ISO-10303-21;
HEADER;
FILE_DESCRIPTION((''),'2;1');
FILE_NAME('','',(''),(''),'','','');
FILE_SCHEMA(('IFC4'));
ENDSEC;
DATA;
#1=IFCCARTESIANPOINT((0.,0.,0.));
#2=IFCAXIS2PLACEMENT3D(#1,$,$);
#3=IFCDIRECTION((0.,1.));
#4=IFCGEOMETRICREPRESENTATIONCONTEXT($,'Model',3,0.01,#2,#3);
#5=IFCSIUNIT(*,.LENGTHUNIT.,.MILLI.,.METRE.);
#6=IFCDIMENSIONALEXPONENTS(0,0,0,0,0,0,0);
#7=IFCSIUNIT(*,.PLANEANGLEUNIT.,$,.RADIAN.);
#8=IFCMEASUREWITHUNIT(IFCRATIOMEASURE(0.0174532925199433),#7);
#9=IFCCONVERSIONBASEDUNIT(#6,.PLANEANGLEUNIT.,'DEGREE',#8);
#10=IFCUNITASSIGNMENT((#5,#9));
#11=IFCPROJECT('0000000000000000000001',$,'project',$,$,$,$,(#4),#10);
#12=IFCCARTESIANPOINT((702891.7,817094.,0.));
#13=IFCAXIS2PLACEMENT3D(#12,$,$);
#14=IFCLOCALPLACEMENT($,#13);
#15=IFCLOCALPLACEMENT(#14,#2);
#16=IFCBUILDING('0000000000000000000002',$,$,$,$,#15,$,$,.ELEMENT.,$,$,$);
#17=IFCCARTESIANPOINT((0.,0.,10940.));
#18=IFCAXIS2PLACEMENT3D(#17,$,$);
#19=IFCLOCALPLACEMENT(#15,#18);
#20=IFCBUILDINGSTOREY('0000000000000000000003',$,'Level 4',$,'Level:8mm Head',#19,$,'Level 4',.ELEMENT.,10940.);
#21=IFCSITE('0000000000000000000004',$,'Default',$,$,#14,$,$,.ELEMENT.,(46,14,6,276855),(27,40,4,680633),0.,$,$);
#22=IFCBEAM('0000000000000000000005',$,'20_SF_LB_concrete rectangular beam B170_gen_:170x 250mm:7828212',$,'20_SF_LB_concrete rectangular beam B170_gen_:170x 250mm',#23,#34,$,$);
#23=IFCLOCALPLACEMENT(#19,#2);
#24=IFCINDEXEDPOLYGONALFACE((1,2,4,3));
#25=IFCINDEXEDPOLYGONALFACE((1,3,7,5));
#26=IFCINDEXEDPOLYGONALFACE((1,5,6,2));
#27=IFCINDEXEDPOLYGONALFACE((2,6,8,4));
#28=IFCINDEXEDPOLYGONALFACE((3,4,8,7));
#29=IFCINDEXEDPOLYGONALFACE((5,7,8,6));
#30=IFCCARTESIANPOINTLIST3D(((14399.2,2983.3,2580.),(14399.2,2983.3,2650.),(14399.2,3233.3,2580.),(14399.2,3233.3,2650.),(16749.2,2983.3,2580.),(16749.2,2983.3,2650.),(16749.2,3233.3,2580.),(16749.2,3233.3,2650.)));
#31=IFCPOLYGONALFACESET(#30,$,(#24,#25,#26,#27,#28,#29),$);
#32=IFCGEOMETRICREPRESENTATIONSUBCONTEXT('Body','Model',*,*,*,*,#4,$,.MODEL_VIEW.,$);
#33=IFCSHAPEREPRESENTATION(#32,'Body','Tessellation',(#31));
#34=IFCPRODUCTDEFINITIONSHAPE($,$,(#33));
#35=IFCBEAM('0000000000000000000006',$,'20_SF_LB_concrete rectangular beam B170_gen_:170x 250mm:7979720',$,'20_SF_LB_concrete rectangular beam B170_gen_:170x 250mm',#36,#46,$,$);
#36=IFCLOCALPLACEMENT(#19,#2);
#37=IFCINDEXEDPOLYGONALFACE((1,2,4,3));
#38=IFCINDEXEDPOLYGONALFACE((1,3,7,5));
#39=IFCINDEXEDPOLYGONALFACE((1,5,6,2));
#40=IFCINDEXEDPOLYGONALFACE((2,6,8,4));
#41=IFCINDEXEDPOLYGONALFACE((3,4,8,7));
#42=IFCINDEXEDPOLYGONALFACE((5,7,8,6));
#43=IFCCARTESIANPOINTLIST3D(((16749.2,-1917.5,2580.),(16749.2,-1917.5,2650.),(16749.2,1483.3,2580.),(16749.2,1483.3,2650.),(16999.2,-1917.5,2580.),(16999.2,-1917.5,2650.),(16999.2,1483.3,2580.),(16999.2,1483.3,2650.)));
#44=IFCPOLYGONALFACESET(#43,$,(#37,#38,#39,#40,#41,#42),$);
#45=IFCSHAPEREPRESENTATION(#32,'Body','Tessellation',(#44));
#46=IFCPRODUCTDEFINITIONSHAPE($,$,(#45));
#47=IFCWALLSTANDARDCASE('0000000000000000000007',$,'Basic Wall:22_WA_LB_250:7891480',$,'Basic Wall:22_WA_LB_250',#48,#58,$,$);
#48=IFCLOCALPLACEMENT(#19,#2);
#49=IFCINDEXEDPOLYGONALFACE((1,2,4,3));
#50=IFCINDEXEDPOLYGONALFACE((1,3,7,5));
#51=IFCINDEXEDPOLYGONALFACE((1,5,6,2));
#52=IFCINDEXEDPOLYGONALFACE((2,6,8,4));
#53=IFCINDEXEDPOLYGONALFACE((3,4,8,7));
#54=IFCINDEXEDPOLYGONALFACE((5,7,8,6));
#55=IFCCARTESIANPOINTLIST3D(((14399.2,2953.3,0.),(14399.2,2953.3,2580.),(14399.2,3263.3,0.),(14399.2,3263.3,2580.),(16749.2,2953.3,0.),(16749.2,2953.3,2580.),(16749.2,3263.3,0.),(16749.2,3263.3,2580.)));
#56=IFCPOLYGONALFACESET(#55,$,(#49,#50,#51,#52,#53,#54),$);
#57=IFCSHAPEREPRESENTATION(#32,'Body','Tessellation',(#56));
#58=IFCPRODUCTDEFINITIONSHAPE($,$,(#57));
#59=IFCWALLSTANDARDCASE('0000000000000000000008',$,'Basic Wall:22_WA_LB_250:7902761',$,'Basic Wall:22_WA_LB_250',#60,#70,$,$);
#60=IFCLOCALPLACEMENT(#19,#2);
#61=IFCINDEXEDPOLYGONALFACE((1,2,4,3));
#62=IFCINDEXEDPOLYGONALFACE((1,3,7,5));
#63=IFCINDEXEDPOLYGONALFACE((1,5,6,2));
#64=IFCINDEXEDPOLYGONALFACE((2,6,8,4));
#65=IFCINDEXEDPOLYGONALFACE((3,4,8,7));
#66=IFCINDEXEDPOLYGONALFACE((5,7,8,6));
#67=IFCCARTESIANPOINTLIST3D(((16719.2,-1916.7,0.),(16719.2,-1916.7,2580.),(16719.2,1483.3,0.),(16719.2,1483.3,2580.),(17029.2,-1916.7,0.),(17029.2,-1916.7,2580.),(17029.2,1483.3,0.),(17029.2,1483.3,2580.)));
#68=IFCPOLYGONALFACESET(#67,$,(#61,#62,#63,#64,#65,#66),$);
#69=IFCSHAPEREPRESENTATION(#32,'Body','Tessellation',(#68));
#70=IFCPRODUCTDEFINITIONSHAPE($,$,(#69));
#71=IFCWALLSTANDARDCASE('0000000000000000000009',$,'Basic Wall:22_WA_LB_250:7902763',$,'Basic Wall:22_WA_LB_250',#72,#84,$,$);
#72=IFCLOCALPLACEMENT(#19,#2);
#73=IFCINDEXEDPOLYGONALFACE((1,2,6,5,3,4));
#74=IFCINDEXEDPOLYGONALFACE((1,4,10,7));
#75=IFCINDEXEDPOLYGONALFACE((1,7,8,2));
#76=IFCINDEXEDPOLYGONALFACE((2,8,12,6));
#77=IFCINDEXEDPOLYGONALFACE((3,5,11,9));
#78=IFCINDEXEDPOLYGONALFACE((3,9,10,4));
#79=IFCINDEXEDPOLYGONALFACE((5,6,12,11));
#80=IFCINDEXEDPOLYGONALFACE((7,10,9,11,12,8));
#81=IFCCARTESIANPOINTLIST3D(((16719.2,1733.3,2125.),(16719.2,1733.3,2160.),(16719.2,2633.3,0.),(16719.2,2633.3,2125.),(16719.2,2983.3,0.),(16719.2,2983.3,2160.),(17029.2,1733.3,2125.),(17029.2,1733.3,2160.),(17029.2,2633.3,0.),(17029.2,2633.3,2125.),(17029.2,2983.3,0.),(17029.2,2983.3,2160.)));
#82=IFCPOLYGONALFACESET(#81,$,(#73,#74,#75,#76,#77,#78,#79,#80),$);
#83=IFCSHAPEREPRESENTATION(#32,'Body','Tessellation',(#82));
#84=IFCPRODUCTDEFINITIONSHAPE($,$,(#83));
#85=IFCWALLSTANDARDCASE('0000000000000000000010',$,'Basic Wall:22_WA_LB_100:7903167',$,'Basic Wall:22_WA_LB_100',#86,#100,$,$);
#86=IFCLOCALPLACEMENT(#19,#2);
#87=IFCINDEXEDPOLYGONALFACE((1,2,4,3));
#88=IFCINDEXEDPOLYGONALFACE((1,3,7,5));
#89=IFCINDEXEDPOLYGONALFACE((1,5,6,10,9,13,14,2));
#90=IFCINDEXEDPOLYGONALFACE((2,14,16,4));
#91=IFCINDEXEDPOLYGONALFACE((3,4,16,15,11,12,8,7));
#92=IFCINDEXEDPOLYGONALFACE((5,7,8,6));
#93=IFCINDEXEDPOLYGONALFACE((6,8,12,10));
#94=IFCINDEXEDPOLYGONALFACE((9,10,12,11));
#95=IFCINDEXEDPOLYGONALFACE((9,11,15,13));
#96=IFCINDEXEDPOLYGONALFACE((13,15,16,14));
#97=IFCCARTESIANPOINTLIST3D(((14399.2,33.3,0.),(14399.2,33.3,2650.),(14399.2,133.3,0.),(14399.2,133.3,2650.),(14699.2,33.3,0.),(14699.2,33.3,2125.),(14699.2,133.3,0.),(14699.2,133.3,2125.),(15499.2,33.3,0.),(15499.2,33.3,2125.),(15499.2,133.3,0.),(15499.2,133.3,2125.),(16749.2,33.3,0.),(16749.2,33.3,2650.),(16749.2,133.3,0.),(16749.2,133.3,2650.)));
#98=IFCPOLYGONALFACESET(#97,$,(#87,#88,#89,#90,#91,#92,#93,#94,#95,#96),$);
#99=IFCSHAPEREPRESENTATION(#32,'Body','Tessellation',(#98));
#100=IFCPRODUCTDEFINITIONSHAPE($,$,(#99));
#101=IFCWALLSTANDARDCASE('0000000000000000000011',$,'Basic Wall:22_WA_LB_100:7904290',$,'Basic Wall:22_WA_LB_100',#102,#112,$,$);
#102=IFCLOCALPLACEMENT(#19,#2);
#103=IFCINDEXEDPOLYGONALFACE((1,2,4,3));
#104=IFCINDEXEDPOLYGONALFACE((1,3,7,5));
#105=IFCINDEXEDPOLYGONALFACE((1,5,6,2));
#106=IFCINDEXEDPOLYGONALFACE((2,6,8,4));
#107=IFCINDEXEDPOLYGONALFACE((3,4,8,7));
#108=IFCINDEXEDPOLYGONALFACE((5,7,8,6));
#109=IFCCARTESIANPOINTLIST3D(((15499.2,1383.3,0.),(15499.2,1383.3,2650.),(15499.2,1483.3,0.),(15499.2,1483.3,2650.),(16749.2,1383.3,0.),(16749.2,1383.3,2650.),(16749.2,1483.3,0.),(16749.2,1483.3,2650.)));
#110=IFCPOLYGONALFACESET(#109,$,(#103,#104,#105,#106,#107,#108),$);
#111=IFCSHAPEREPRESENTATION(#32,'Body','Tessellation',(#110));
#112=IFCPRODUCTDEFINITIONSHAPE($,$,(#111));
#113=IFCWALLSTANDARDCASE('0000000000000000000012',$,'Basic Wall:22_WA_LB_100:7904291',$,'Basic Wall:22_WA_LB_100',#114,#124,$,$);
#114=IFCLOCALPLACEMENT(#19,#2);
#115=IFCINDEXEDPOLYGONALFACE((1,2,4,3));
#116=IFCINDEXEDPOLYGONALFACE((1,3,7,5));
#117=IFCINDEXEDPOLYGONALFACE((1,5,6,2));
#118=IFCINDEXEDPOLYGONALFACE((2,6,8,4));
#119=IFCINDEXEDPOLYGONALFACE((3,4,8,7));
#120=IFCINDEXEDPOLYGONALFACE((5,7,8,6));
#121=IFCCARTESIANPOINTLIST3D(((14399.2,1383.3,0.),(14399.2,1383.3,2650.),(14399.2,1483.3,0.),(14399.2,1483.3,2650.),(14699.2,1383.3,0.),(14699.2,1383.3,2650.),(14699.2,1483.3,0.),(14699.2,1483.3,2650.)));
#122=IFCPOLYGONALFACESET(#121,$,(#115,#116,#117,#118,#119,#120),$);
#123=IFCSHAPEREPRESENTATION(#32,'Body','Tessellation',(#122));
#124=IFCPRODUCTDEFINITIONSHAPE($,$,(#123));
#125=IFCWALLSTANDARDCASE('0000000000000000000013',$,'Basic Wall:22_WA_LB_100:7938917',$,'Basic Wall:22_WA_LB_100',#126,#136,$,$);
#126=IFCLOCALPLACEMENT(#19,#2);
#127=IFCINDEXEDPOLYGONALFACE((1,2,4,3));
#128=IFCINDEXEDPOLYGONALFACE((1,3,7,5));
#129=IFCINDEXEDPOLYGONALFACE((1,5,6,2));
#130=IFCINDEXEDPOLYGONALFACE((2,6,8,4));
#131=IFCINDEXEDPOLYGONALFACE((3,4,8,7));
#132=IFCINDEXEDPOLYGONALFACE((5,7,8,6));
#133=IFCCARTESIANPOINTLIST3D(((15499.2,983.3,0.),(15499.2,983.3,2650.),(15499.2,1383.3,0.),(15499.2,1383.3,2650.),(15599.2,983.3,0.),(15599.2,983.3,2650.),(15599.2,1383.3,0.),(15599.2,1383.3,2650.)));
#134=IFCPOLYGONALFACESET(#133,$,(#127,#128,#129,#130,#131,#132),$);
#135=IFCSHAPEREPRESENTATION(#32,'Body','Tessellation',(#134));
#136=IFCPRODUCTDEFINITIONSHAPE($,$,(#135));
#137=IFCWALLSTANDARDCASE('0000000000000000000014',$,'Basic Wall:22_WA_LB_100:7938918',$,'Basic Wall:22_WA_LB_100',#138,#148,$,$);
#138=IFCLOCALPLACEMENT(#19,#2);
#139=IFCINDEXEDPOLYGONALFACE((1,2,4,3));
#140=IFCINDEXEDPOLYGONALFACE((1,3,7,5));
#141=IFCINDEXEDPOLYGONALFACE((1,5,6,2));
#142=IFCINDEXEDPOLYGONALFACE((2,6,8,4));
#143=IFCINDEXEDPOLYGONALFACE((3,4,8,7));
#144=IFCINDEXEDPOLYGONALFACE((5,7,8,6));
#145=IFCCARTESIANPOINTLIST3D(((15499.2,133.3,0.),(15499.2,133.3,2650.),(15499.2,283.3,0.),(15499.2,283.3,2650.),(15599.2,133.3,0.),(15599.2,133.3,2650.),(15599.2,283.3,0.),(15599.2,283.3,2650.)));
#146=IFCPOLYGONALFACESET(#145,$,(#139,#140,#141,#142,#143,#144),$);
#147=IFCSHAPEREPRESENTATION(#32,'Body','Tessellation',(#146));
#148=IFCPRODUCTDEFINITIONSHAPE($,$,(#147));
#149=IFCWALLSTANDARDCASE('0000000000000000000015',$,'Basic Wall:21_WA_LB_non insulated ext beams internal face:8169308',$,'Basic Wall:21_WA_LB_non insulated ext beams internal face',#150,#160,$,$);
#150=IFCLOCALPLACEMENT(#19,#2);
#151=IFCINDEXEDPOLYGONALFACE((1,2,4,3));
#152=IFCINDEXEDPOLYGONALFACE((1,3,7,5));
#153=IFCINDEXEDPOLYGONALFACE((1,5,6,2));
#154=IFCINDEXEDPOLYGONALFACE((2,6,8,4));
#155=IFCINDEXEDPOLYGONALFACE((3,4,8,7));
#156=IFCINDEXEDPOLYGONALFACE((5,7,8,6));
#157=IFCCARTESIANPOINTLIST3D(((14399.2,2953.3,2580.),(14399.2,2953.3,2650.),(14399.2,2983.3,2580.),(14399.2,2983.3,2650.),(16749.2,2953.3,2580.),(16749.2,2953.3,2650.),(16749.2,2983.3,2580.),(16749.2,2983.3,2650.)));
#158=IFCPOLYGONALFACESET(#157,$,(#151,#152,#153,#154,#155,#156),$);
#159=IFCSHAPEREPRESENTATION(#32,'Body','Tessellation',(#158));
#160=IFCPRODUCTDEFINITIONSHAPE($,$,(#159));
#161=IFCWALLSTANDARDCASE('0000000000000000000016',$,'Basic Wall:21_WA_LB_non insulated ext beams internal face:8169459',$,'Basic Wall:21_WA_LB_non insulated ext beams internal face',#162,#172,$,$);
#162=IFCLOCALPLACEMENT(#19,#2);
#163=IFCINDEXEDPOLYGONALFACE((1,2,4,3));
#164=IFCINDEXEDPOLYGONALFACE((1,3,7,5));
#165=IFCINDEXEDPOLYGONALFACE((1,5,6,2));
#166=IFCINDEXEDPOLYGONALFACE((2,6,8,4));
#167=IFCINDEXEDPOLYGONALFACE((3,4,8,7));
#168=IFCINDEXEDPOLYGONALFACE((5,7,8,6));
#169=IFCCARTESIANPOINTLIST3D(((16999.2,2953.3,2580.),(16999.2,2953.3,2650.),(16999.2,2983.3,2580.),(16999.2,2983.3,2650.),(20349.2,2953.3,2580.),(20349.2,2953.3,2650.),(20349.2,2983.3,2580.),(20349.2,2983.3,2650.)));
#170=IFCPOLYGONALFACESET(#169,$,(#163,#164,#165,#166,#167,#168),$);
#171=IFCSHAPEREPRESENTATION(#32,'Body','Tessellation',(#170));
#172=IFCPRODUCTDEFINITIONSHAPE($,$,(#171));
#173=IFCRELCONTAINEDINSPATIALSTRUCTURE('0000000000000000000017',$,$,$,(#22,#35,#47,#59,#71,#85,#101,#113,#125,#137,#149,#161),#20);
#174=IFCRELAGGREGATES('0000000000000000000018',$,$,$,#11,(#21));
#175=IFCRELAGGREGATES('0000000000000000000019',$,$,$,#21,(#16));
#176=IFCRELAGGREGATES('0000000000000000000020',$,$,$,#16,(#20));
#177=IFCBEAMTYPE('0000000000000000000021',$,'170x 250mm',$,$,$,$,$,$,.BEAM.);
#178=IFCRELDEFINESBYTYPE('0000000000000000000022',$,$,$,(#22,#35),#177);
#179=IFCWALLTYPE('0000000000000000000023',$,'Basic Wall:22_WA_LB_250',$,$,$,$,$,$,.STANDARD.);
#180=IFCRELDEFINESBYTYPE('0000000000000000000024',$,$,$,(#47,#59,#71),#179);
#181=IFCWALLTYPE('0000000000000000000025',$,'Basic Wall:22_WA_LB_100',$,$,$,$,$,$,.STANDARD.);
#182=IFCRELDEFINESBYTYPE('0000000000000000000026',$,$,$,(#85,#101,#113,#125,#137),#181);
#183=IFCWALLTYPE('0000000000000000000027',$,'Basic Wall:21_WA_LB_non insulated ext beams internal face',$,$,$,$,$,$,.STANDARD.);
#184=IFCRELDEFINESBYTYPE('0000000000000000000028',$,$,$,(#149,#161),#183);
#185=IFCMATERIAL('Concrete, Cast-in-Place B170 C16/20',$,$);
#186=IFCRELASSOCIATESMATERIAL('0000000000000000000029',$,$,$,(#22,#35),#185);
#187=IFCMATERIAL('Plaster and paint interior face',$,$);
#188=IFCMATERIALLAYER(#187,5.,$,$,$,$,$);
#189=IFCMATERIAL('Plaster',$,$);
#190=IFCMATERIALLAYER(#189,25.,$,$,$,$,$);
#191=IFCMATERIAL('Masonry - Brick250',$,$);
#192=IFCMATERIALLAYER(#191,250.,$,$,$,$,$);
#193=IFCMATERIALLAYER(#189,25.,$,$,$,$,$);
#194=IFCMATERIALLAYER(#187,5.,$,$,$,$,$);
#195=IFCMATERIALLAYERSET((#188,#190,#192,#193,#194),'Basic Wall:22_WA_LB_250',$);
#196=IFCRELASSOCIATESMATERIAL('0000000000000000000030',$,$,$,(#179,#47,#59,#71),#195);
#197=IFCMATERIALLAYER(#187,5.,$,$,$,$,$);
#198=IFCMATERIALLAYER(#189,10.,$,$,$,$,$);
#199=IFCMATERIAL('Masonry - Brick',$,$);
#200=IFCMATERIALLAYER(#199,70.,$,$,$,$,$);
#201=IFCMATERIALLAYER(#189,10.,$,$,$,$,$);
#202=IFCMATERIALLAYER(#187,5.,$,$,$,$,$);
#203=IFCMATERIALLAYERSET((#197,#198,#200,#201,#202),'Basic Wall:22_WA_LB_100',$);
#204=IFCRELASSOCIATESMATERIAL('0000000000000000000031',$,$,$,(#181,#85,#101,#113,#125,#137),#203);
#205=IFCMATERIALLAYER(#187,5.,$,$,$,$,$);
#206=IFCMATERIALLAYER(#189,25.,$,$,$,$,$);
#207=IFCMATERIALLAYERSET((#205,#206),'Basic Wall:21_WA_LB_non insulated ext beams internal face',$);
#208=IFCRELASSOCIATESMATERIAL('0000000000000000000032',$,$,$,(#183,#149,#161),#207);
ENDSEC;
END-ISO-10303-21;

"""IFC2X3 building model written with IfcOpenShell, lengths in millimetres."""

from ifc_helpers import new_model, entity, si_unit, converted_unit, direction, frame, frame_2d, origin, place, context, subcontext, project, spatial, rectangle, extrude, material, layer, layer_set, layer_usage, type_object, element, save


model = new_model("IFC2X3")

# Units and contexts
model_context = context("Model", 3, precision=0.01, world=origin(), true_north=direction((0.0, 1.0)))
body_context = subcontext(model_context, "Body", "Model", "MODEL_VIEW")
ifc_project = project(units=[si_unit("LENGTHUNIT", "METRE", prefix="MILLI"), converted_unit("PLANEANGLEUNIT", "DEGREE", entity("IfcRatioMeasure", 0.0174532925199433), si_unit("PLANEANGLEUNIT", "RADIAN"), dimensions=[0, 0, 0, 0, 0, 0, 0])], contexts=[model_context])

# Site, building, storey
site_placement = place(None, frame((702891.7, 817094.0, 0.0)))
site = spatial("IfcSite", under=ifc_project, at=site_placement, Name="Default", CompositionType="ELEMENT", RefLatitude=(46, 14, 6, 276855), RefLongitude=(27, 40, 4, 680633), RefElevation=0.0)
building_placement = place(site_placement, origin())
building = spatial("IfcBuilding", under=site, at=building_placement, CompositionType="ELEMENT")
storey_placement = place(building_placement, frame((0.0, 0.0, 10940.0)))
storey = spatial("IfcBuildingStorey", under=building, at=storey_placement, Name="Level 4", ObjectType="Level:8mm Head", LongName="Level 4", CompositionType="ELEMENT", Elevation=10940.0)

# Beams
ifc_material_1 = material(Name="Concrete, Cast-in-Place B170 C16/20")
beam_type = type_object("IfcBeamType", Name="170x 250mm", PredefinedType="BEAM")
beam_1_placement = place(storey_placement, frame((14399.2, 3108.3, 0.0)))
element("IfcBeam", 1, at=beam_1_placement, inside=storey, type_object=beam_type, material=ifc_material_1, Name="20_SF_LB_concrete rectangular beam B170_gen_:170x 250mm:7828212", ObjectType="20_SF_LB_concrete rectangular beam B170_gen_:170x 250mm", context=body_context, shape_type="SweptSolid", body=[
    extrude(rectangle(XDim=70.0, YDim=250.0, at=frame_2d((0.0, 0.0), x_axis=(1.0, 0.0))), frame((0.0, 0.0, 2615.0), z_axis=(1.0, 0.0, 0.0), x_axis=(0.0, 0.0, -1.0)), (0.0, 0.0, 1.0), 2350.0),
])
beam_2_placement = place(storey_placement, frame((16874.2, 1483.3, 0.0), z_axis=(0.0, 0.0, 1.0), x_axis=(0.0, -1.0, 0.0)))
element("IfcBeam", 2, at=beam_2_placement, inside=storey, type_object=beam_type, material=ifc_material_1, Name="20_SF_LB_concrete rectangular beam B170_gen_:170x 250mm:7979720", ObjectType="20_SF_LB_concrete rectangular beam B170_gen_:170x 250mm", context=body_context, shape_type="SweptSolid", body=[
    extrude(rectangle(XDim=70.0, YDim=250.0, at=frame_2d((0.0, 0.0), x_axis=(1.0, 0.0))), frame((0.0, 0.0, 2615.0), z_axis=(1.0, 0.0, 0.0), x_axis=(0.0, 0.0, -1.0)), (0.0, 0.0, 1.0), 3400.8),
])

# Walls
ifc_material_2 = material(Name="Plaster and paint interior face")
ifc_layer_1 = layer(ifc_material_2, 5.0)
ifc_material_3 = material(Name="Plaster")
ifc_layer_2 = layer(ifc_material_3, 25.0)
ifc_material_4 = material(Name="Masonry - Brick250")
ifc_layer_3 = layer(ifc_material_4, 250.0)
ifc_layer_4 = layer(ifc_material_3, 25.0)
ifc_layer_5 = layer(ifc_material_2, 5.0)
ifc_layer_set_1 = layer_set([ifc_layer_1, ifc_layer_2, ifc_layer_3, ifc_layer_4, ifc_layer_5], Name="Basic Wall:22_WA_LB_250")
ifc_layer_usage_1 = layer_usage(ifc_layer_set_1, "AXIS2", "NEGATIVE", 155.0)
wall_type_1 = type_object("IfcWallType", Name="Basic Wall:22_WA_LB_250", PredefinedType="STANDARD", material=ifc_layer_set_1)
wall_1_placement = place(storey_placement, frame((14399.2, 3108.3, 0.0)))
element("IfcWallStandardCase", 3, at=wall_1_placement, inside=storey, type_object=wall_type_1, material=ifc_layer_usage_1, Name="Basic Wall:22_WA_LB_250:7891480", ObjectType="Basic Wall:22_WA_LB_250", context=body_context, shape_type="SweptSolid", body=[
    extrude(rectangle(XDim=2350.0, YDim=310.0, at=frame_2d((1175.0, 0.0), x_axis=(-1.0, 0.0))), origin(), (0.0, 0.0, 1.0), 2580.0),
])
ifc_layer_usage_2 = layer_usage(ifc_layer_set_1, "AXIS2", "NEGATIVE", 155.0)
wall_2_placement = place(storey_placement, frame((16874.2, 1483.3, 0.0), z_axis=(0.0, 0.0, 1.0), x_axis=(0.0, -1.0, 0.0)))
element("IfcWallStandardCase", 4, at=wall_2_placement, inside=storey, type_object=wall_type_1, material=ifc_layer_usage_2, Name="Basic Wall:22_WA_LB_250:7902761", ObjectType="Basic Wall:22_WA_LB_250", context=body_context, shape_type="SweptSolid", body=[
    extrude(rectangle(XDim=3400.0, YDim=310.0, at=frame_2d((1700.0, 0.0), x_axis=(-1.0, 0.0))), origin(), (0.0, 0.0, 1.0), 2580.0),
])

# Walls, openings
ifc_layer_usage_3 = layer_usage(ifc_layer_set_1, "AXIS2", "NEGATIVE", 155.0)
wall_3_placement = place(storey_placement, frame((16874.2, 2983.3, 0.0), z_axis=(0.0, 0.0, 1.0), x_axis=(0.0, -1.0, 0.0)))
wall_3 = element("IfcWallStandardCase", 5, at=wall_3_placement, inside=storey, type_object=wall_type_1, material=ifc_layer_usage_3, Name="Basic Wall:22_WA_LB_250:7902763", ObjectType="Basic Wall:22_WA_LB_250", context=body_context, shape_type="SweptSolid", body=[
    extrude(rectangle(XDim=1250.0, YDim=310.0, at=frame_2d((625.0, 0.0), x_axis=(-1.0, 0.0))), origin(), (0.0, 0.0, 1.0), 2160.0),
])
opening_1_placement = place(wall_3_placement, frame((2983.3, -16874.2, 0.0), z_axis=(0.0, 0.0, 1.0), x_axis=(0.0, 1.0, 0.0)))
element("IfcOpeningElement", 6, at=opening_1_placement, cuts=wall_3, ObjectType="Opening", context=body_context, shape_type="SweptSolid", body=[
    extrude(rectangle(XDim=2125.0, YDim=900.0, at=frame_2d((0.0, 0.0), x_axis=(0.0, 1.0))), frame((15195.2, 2183.3, 1062.5), z_axis=(1.0, 0.0, 0.0), x_axis=(0.0, 1.0, 0.0)), (0.0, 0.0, 1.0), 3048.0),
])
ifc_layer_6 = layer(ifc_material_2, 5.0)
ifc_layer_7 = layer(ifc_material_3, 10.0)
ifc_material_5 = material(Name="Masonry - Brick")
ifc_layer_8 = layer(ifc_material_5, 70.0)
ifc_layer_9 = layer(ifc_material_3, 10.0)
ifc_layer_10 = layer(ifc_material_2, 5.0)
ifc_layer_set_2 = layer_set([ifc_layer_6, ifc_layer_7, ifc_layer_8, ifc_layer_9, ifc_layer_10], Name="Basic Wall:22_WA_LB_100")
ifc_layer_usage_4 = layer_usage(ifc_layer_set_2, "AXIS2", "NEGATIVE", 50.0)
wall_type_2 = type_object("IfcWallType", Name="Basic Wall:22_WA_LB_100", PredefinedType="STANDARD", material=ifc_layer_set_2)
wall_4_placement = place(storey_placement, frame((16749.2, 83.3, 0.0), z_axis=(0.0, 0.0, 1.0), x_axis=(-1.0, 0.0, 0.0)))
wall_4 = element("IfcWallStandardCase", 7, at=wall_4_placement, inside=storey, type_object=wall_type_2, material=ifc_layer_usage_4, Name="Basic Wall:22_WA_LB_100:7903167", ObjectType="Basic Wall:22_WA_LB_100", context=body_context, shape_type="SweptSolid", body=[
    extrude(rectangle(XDim=2350.0, YDim=100.0, at=frame_2d((1175.0, 0.0), x_axis=(-1.0, 0.0))), origin(), (0.0, 0.0, 1.0), 2650.0),
])
opening_2_placement = place(wall_4_placement, frame((16749.2, 83.3, 0.0), z_axis=(0.0, 0.0, 1.0), x_axis=(-1.0, 0.0, 0.0)))
element("IfcOpeningElement", 8, at=opening_2_placement, cuts=wall_4, ObjectType="Opening", context=body_context, shape_type="SweptSolid", body=[
    extrude(rectangle(XDim=2125.0, YDim=800.0, at=frame_2d((0.0, 0.0), x_axis=(1.0, 0.0))), frame((15099.2, 1657.3, 1062.5), z_axis=(0.0, -1.0, 0.0), x_axis=(0.0, 0.0, 1.0)), (0.0, 0.0, 1.0), 3048.0),
])

# Walls
ifc_layer_usage_5 = layer_usage(ifc_layer_set_2, "AXIS2", "NEGATIVE", 50.0)
wall_5_placement = place(storey_placement, frame((15499.2, 1433.3, 0.0)))
element("IfcWallStandardCase", 9, at=wall_5_placement, inside=storey, type_object=wall_type_2, material=ifc_layer_usage_5, Name="Basic Wall:22_WA_LB_100:7904290", ObjectType="Basic Wall:22_WA_LB_100", context=body_context, shape_type="SweptSolid", body=[
    extrude(rectangle(XDim=1250.0, YDim=100.0, at=frame_2d((625.0, 0.0), x_axis=(-1.0, 0.0))), origin(), (0.0, 0.0, 1.0), 2650.0),
])
ifc_layer_usage_6 = layer_usage(ifc_layer_set_2, "AXIS2", "NEGATIVE", 50.0)
wall_6_placement = place(storey_placement, frame((14399.2, 1433.3, 0.0)))
element("IfcWallStandardCase", 10, at=wall_6_placement, inside=storey, type_object=wall_type_2, material=ifc_layer_usage_6, Name="Basic Wall:22_WA_LB_100:7904291", ObjectType="Basic Wall:22_WA_LB_100", context=body_context, shape_type="SweptSolid", body=[
    extrude(rectangle(XDim=300.0, YDim=100.0, at=frame_2d((150.0, 0.0), x_axis=(-1.0, 0.0))), origin(), (0.0, 0.0, 1.0), 2650.0),
])
ifc_layer_usage_7 = layer_usage(ifc_layer_set_2, "AXIS2", "NEGATIVE", 50.0)
wall_7_placement = place(storey_placement, frame((15549.2, 1383.3, 0.0), z_axis=(0.0, 0.0, 1.0), x_axis=(0.0, -1.0, 0.0)))
element("IfcWallStandardCase", 11, at=wall_7_placement, inside=storey, type_object=wall_type_2, material=ifc_layer_usage_7, Name="Basic Wall:22_WA_LB_100:7938917", ObjectType="Basic Wall:22_WA_LB_100", context=body_context, shape_type="SweptSolid", body=[
    extrude(rectangle(XDim=400.0, YDim=100.0, at=frame_2d((200.0, 0.0), x_axis=(-1.0, 0.0))), origin(), (0.0, 0.0, 1.0), 2650.0),
])
ifc_layer_usage_8 = layer_usage(ifc_layer_set_2, "AXIS2", "NEGATIVE", 50.0)
wall_8_placement = place(storey_placement, frame((15549.2, 283.3, 0.0), z_axis=(0.0, 0.0, 1.0), x_axis=(0.0, -1.0, 0.0)))
element("IfcWallStandardCase", 12, at=wall_8_placement, inside=storey, type_object=wall_type_2, material=ifc_layer_usage_8, Name="Basic Wall:22_WA_LB_100:7938918", ObjectType="Basic Wall:22_WA_LB_100", context=body_context, shape_type="SweptSolid", body=[
    extrude(rectangle(XDim=150.0, YDim=100.0, at=frame_2d((75.0, 0.0), x_axis=(-1.0, 0.0))), origin(), (0.0, 0.0, 1.0), 2650.0),
])
ifc_layer_11 = layer(ifc_material_2, 5.0)
ifc_layer_12 = layer(ifc_material_3, 25.0)
ifc_layer_set_3 = layer_set([ifc_layer_11, ifc_layer_12], Name="Basic Wall:21_WA_LB_non insulated ext beams internal face")
ifc_layer_usage_9 = layer_usage(ifc_layer_set_3, "AXIS2", "POSITIVE", -15.0)
wall_type_3 = type_object("IfcWallType", Name="Basic Wall:21_WA_LB_non insulated ext beams internal face", PredefinedType="STANDARD", material=ifc_layer_set_3)
wall_9_placement = place(storey_placement, frame((14399.2, 2968.3, 2580.0)))
element("IfcWallStandardCase", 13, at=wall_9_placement, inside=storey, type_object=wall_type_3, material=ifc_layer_usage_9, Name="Basic Wall:21_WA_LB_non insulated ext beams internal face:8169308", ObjectType="Basic Wall:21_WA_LB_non insulated ext beams internal face", context=body_context, shape_type="SweptSolid", body=[
    extrude(rectangle(XDim=2350.0, YDim=30.0, at=frame_2d((1175.0, 0.0), x_axis=(-1.0, 0.0))), origin(), (0.0, 0.0, 1.0), 70.0),
])
ifc_layer_usage_10 = layer_usage(ifc_layer_set_3, "AXIS2", "POSITIVE", -15.0)
wall_10_placement = place(storey_placement, frame((16999.2, 2968.3, 2580.0)))
element("IfcWallStandardCase", 14, at=wall_10_placement, inside=storey, type_object=wall_type_3, material=ifc_layer_usage_10, Name="Basic Wall:21_WA_LB_non insulated ext beams internal face:8169459", ObjectType="Basic Wall:21_WA_LB_non insulated ext beams internal face", context=body_context, shape_type="SweptSolid", body=[
    extrude(rectangle(XDim=3350.0, YDim=30.0, at=frame_2d((1675.0, 0.0), x_axis=(-1.0, 0.0))), origin(), (0.0, 0.0, 1.0), 70.0),
])

save(model, "model.ifc")
